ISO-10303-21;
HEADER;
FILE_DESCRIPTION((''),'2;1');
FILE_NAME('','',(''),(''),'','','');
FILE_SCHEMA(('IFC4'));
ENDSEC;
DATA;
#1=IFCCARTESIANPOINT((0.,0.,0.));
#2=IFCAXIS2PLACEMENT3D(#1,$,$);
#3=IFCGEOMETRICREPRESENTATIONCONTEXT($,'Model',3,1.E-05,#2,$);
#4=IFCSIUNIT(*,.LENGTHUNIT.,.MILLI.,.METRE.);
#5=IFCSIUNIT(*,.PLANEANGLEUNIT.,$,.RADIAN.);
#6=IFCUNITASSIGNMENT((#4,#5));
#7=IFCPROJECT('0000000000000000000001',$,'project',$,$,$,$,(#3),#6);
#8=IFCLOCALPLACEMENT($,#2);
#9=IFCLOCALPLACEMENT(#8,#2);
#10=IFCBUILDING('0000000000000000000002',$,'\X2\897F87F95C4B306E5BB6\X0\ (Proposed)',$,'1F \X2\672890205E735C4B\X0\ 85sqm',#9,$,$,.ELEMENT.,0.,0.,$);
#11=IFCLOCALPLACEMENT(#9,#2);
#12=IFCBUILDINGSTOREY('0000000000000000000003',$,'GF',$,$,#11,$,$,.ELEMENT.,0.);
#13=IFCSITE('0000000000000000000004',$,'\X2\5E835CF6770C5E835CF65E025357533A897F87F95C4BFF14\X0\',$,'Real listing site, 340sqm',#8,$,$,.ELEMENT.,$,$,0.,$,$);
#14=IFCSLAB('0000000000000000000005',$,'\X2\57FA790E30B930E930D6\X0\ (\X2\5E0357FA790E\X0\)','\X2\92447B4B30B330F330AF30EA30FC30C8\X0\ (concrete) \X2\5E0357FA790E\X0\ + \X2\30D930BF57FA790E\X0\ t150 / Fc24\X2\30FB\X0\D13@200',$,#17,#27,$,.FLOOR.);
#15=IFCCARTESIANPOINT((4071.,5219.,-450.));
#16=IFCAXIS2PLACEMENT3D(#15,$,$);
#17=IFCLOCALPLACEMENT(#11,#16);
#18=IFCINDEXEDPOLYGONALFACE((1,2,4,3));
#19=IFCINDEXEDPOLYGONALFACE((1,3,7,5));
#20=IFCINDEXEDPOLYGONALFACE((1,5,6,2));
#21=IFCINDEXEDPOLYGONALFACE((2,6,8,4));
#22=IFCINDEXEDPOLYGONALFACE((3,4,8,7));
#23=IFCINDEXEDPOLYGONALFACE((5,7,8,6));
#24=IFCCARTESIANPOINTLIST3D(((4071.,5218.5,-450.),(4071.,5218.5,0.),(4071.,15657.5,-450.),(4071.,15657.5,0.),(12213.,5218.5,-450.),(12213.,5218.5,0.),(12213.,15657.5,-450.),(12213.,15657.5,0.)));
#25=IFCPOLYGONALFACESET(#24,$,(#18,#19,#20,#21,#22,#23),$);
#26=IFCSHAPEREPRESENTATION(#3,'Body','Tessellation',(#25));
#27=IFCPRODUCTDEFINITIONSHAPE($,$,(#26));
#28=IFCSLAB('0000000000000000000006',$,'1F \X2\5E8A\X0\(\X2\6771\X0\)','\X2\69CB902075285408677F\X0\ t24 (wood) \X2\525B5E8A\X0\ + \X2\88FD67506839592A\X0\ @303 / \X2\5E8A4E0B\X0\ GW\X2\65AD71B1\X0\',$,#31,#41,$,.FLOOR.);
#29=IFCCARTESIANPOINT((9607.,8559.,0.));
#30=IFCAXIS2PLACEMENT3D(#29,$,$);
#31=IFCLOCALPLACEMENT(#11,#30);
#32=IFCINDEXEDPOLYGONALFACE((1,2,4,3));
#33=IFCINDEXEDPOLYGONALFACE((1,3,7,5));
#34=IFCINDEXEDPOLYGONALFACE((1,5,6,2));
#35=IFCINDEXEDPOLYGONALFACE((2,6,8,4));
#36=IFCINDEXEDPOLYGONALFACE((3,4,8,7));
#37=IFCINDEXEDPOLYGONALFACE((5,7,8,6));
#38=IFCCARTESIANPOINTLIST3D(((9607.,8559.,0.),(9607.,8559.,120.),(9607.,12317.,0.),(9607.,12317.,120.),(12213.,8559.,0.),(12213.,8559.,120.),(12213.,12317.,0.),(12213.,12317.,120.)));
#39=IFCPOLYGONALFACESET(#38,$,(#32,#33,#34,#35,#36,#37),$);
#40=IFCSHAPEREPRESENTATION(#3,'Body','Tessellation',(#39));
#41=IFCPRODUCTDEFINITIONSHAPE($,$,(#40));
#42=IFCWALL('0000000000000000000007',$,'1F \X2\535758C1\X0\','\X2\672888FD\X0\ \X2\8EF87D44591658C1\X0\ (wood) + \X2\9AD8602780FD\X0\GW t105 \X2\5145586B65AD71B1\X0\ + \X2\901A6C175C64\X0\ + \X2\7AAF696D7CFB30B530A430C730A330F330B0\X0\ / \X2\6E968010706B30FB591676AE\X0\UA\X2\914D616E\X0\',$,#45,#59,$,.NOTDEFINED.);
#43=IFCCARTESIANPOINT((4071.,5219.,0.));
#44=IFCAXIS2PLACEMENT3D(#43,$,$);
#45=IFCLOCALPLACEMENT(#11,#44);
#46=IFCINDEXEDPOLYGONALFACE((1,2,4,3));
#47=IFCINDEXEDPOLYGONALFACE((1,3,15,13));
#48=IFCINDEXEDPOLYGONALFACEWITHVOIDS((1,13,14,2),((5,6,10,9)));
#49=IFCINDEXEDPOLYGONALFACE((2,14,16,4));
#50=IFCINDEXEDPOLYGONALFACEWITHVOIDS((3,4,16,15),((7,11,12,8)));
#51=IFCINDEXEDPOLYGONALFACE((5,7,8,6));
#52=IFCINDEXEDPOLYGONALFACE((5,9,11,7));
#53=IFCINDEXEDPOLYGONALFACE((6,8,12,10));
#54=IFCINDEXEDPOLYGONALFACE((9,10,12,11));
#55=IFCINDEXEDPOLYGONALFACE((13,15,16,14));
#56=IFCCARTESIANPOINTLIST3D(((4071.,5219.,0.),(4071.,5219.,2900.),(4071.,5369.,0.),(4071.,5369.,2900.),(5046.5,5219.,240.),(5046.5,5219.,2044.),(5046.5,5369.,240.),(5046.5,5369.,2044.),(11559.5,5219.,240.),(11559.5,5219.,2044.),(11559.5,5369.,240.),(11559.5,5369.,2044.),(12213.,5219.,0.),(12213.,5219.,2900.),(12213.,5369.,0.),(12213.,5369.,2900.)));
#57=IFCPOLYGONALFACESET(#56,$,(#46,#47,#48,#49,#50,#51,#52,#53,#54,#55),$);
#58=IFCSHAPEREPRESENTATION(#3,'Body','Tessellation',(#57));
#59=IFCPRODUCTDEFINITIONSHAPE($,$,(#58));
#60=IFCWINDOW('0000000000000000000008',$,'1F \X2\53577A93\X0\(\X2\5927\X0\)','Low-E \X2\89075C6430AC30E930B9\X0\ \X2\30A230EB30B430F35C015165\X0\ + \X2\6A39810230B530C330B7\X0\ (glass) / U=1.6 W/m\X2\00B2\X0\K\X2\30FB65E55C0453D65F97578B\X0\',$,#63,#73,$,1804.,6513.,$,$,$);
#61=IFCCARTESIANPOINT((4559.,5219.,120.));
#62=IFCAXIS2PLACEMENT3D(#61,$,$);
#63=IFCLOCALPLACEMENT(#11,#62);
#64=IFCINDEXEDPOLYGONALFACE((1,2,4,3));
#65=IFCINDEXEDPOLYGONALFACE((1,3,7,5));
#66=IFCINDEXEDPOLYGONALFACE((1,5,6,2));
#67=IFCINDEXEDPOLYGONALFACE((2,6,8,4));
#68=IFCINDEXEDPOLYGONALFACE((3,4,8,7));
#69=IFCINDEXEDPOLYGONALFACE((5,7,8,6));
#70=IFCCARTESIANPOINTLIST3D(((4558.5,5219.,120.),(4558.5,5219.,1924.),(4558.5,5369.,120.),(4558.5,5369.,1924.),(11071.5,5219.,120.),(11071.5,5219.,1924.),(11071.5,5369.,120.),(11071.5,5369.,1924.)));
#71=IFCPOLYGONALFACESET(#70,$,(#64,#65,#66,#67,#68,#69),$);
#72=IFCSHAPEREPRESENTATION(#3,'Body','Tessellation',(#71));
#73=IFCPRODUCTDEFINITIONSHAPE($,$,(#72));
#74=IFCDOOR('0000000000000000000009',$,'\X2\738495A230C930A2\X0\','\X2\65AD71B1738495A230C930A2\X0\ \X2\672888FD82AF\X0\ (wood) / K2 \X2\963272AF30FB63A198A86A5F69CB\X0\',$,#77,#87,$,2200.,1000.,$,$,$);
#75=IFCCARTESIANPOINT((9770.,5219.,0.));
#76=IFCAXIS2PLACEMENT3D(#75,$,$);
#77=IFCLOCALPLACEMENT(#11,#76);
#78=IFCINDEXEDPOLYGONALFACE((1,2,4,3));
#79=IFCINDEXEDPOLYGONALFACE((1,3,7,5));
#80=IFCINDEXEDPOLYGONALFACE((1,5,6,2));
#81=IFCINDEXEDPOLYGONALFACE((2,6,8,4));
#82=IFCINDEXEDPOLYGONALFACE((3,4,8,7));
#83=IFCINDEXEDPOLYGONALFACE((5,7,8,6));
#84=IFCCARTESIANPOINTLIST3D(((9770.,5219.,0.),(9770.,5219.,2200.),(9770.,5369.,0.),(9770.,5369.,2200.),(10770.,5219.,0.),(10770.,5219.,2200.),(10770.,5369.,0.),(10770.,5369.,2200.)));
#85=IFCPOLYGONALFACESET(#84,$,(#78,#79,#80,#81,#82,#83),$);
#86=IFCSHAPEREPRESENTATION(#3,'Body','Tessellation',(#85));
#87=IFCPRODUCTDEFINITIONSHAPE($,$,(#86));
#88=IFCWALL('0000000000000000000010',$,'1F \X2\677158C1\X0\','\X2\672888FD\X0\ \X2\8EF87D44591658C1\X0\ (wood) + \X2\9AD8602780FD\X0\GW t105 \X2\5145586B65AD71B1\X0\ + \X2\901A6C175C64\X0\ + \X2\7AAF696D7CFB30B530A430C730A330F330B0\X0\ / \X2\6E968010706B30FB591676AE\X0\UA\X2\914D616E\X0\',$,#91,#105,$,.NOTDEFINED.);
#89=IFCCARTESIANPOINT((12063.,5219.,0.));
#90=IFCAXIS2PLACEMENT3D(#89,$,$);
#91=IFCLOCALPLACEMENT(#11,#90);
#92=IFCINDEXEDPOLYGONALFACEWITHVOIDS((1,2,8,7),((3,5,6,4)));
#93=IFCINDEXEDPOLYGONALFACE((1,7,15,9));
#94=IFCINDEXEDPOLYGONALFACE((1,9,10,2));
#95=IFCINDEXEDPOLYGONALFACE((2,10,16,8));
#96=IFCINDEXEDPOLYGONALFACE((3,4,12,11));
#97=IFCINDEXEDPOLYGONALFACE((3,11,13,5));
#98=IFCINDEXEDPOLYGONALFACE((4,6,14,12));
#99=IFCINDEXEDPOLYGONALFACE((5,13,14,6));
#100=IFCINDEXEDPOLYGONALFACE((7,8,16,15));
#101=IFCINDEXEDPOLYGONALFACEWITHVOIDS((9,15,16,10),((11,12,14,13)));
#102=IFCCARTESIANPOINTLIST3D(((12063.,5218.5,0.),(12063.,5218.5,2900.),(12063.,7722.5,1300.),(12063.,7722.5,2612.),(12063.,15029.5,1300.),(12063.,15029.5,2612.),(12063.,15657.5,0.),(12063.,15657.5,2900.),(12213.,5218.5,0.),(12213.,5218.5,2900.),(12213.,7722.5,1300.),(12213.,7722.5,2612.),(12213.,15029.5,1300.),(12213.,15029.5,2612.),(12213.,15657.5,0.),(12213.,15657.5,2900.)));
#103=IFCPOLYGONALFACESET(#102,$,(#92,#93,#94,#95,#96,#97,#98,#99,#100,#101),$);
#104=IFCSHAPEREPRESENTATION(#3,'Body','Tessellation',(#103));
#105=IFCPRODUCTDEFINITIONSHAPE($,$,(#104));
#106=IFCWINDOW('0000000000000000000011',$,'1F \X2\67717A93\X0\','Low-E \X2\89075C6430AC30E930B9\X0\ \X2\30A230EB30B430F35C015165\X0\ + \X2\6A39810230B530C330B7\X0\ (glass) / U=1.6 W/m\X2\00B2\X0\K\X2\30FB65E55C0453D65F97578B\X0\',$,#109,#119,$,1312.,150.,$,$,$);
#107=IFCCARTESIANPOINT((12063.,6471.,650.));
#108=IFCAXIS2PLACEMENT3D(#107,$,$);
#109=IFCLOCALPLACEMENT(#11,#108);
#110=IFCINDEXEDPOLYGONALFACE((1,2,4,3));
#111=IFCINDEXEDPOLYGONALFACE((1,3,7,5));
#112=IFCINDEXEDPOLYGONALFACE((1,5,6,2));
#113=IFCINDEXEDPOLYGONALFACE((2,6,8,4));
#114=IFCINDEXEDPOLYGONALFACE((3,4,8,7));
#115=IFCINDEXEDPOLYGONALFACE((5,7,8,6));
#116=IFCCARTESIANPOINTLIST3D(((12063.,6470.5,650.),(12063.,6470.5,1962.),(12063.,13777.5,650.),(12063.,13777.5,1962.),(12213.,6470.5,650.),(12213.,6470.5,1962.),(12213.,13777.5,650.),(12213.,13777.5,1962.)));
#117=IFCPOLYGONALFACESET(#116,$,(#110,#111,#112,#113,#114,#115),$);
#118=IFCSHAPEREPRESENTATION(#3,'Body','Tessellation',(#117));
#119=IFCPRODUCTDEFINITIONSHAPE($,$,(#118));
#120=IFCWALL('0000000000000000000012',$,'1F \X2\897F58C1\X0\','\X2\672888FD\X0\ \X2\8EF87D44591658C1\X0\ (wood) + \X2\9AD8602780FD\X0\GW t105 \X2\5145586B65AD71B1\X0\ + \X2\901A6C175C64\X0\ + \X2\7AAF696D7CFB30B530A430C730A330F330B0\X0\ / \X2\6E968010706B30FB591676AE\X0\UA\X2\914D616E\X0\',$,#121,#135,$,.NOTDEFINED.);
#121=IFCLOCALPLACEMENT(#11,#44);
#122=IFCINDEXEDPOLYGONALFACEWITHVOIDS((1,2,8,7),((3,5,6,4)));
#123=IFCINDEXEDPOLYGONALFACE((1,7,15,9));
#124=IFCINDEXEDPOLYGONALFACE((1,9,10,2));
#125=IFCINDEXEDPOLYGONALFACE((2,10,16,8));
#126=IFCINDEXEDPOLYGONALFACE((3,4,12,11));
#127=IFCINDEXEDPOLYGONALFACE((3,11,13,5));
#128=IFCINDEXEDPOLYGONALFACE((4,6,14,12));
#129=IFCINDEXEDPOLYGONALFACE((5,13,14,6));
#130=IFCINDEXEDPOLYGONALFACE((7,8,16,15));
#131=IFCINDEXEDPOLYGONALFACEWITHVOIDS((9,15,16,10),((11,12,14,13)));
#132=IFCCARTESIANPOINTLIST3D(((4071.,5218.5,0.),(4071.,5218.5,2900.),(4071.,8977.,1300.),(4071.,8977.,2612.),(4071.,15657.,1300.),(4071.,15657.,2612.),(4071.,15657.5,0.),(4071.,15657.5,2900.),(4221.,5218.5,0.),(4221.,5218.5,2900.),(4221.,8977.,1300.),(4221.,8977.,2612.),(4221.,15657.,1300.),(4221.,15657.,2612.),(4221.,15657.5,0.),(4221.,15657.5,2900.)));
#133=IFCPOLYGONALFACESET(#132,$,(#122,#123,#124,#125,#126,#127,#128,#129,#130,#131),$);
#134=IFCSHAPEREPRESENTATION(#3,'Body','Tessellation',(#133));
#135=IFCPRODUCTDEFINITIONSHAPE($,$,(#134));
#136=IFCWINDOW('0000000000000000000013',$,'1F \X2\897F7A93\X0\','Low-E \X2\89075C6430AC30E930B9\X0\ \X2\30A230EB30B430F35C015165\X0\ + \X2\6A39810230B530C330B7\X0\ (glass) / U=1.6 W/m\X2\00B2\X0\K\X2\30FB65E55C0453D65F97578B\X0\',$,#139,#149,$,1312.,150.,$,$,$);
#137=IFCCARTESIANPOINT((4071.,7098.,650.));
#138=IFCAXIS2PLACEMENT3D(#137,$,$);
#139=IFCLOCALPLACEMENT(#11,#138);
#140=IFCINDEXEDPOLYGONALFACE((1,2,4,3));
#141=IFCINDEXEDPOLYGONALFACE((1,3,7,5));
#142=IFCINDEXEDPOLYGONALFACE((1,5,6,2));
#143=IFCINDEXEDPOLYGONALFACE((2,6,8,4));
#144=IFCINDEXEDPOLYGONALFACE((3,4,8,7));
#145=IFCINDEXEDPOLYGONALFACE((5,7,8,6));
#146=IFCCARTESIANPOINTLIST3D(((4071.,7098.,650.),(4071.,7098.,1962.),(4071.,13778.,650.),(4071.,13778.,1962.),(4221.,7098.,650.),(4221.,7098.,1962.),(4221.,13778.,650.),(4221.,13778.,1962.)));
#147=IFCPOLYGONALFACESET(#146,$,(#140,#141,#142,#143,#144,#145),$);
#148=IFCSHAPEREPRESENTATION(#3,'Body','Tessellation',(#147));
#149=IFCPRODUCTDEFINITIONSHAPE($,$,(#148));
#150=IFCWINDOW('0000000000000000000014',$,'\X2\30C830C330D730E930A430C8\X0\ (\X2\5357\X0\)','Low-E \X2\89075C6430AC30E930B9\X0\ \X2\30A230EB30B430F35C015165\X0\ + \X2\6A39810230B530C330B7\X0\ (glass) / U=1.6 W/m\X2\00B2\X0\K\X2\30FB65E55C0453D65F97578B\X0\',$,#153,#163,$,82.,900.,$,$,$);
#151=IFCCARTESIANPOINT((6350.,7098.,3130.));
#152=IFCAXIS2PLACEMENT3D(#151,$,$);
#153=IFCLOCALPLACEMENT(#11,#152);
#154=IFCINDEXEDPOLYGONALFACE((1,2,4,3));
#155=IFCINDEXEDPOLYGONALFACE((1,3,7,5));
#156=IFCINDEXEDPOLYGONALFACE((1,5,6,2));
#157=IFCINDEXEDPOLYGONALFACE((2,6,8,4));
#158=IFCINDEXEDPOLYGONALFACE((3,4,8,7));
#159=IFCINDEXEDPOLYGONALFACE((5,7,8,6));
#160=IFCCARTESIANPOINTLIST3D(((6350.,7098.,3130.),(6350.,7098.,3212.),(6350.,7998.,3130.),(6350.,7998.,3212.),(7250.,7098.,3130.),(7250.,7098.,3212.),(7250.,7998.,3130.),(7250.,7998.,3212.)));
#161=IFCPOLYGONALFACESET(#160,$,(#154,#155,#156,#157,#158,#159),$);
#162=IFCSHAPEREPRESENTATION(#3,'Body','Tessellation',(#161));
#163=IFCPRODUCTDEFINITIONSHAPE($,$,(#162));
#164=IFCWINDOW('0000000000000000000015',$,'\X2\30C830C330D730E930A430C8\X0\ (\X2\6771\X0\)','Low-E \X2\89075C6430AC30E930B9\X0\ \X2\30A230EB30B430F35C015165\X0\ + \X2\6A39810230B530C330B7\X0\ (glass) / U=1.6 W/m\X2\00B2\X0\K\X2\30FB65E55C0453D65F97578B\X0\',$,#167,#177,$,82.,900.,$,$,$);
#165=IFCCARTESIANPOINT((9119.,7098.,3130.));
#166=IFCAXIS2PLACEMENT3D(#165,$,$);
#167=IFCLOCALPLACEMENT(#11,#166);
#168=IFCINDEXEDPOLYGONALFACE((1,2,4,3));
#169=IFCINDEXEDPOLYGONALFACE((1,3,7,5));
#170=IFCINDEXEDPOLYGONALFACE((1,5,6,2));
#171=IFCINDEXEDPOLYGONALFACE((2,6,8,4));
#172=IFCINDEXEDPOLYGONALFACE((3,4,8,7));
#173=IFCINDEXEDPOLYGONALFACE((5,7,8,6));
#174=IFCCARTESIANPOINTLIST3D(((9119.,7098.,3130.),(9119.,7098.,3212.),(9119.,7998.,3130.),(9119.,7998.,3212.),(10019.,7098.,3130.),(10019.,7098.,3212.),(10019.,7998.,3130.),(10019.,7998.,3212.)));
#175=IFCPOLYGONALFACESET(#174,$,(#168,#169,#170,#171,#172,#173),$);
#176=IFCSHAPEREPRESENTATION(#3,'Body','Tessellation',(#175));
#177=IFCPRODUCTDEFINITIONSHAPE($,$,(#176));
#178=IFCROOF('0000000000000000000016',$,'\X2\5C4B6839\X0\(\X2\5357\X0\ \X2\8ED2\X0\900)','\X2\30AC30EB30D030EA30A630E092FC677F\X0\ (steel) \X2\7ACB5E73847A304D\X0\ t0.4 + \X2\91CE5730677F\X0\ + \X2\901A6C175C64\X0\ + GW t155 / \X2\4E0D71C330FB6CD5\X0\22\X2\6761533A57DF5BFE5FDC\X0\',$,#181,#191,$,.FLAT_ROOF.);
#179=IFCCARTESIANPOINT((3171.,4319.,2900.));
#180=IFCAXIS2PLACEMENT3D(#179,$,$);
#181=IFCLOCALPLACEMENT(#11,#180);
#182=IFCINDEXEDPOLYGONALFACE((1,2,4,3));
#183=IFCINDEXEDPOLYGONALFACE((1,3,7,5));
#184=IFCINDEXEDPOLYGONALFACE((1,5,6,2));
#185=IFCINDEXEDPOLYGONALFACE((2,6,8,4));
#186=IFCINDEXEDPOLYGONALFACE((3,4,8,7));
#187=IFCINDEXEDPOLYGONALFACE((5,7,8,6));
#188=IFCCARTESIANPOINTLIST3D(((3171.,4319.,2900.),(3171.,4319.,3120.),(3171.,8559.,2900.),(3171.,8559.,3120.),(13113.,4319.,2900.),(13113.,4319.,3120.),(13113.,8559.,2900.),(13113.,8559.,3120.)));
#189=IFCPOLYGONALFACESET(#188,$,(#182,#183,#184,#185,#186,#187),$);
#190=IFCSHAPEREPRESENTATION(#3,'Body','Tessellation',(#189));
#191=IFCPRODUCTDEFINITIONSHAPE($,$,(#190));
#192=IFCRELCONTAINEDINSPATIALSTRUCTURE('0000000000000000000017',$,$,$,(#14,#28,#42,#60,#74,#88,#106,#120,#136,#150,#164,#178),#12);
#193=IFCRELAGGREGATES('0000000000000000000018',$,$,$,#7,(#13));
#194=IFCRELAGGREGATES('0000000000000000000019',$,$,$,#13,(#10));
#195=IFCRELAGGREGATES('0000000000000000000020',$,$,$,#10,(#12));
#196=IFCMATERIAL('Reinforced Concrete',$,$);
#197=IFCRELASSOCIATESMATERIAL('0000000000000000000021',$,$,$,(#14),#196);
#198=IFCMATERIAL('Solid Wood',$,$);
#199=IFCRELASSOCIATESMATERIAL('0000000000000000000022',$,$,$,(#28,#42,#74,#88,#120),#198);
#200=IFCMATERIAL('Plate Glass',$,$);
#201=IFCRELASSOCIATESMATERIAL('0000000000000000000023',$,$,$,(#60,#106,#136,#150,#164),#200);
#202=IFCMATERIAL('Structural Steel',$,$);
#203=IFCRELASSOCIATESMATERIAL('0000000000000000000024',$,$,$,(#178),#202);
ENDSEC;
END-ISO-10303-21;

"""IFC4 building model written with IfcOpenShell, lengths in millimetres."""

from ifc_helpers import new_model, si_unit, frame, frame_2d, origin, place, context, project, spatial, rectangle, extrude, material, element, fill, save


model = new_model("IFC4")

# Units and contexts
model_context = context("Model", 3, precision=1e-05, world=origin())
ifc_project = project(units=[si_unit("LENGTHUNIT", "METRE", prefix="MILLI"), si_unit("PLANEANGLEUNIT", "RADIAN")], contexts=[model_context])

# Site, building, storey
site_placement = place(None, origin())
site = spatial("IfcSite", under=ifc_project, at=site_placement, Name="広島県広島市南区西蟹屋４", ObjectType="Real listing site, 340sqm", CompositionType="ELEMENT", RefElevation=0.0)
building_placement = place(site_placement, origin())
building = spatial("IfcBuilding", under=site, at=building_placement, Name="西蟹屋の家 (Proposed)", ObjectType="1F 木造平屋 85sqm", CompositionType="ELEMENT", ElevationOfRefHeight=0.0, ElevationOfTerrain=0.0)
storey_placement = place(building_placement, origin())
storey = spatial("IfcBuildingStorey", under=building, at=storey_placement, Name="GF", CompositionType="ELEMENT", Elevation=0.0)

# Slabs
ifc_material_1 = material(Name="Reinforced Concrete")
slab_1_placement = place(storey_placement, frame((4071.0, 5219.0, -450.0)))
element("IfcSlab", 1, at=slab_1_placement, inside=storey, material=ifc_material_1, Name="基礎スラブ (布基礎)", Description="鉄筋コンクリート (concrete) 布基礎 + ベタ基礎 t150 / Fc24・D13@200", PredefinedType="FLOOR", context=model_context, shape_type="SweptSolid", body=[
    extrude(rectangle(XDim=8142.0, YDim=10439.0, at=frame_2d((4071.0, 5219.0))), frame((4071.0, 5219.0, -450.0)), (0.0, 0.0, 1.0), 450.0),
])
ifc_material_2 = material(Name="Solid Wood")
slab_2_placement = place(storey_placement, frame((9607.0, 8559.0, 0.0)))
element("IfcSlab", 2, at=slab_2_placement, inside=storey, material=ifc_material_2, Name="1F 床(東)", Description="構造用合板 t24 (wood) 剛床 + 製材根太 @303 / 床下 GW断熱", PredefinedType="FLOOR", context=model_context, shape_type="SweptSolid", body=[
    extrude(rectangle(XDim=2606.0, YDim=3758.0, at=frame_2d((1303.0, 1879.0))), frame((9607.0, 8559.0, 0.0)), (0.0, 0.0, 1.0), 120.0),
])

# Wall, openings, window, door
wall_1_placement = place(storey_placement, frame((4071.0, 5219.0, 0.0)))
wall_1 = element("IfcWall", 3, at=wall_1_placement, inside=storey, material=ifc_material_2, Name="1F 南壁", Description="木製 軸組外壁 (wood) + 高性能GW t105 充填断熱 + 通気層 + 窯業系サイディング / 準耐火・外皮UA配慮", PredefinedType="NOTDEFINED", context=model_context, shape_type="SweptSolid", body=[
    extrude(rectangle(XDim=8142.0, YDim=150.0, at=frame_2d((4071.0, 75.0))), frame((4071.0, 5219.0, 0.0)), (0.0, 0.0, 1.0), 2900.0),
])
opening_1_placement = place(storey_placement, frame((4559.0, 5219.0, 120.0)))
opening_1 = element("IfcOpeningElement", 4, at=opening_1_placement, cuts=wall_1, PredefinedType="NOTDEFINED", context=model_context, shape_type="SweptSolid", body=[
    extrude(rectangle(XDim=6513.0, YDim=150.0, at=frame_2d((3256.0, 75.0))), frame((4559.0, 5219.0, 120.0)), (0.0, 0.0, 1.0), 1804.0),
])
opening_2_placement = place(storey_placement, frame((9770.0, 5219.0, 0.0)))
opening_2 = element("IfcOpeningElement", 5, at=opening_2_placement, cuts=wall_1, PredefinedType="NOTDEFINED", context=model_context, shape_type="SweptSolid", body=[
    extrude(rectangle(XDim=1000.0, YDim=150.0, at=frame_2d((500.0, 75.0))), frame((9770.0, 5219.0, 0.0)), (0.0, 0.0, 1.0), 2200.0),
])
ifc_material_3 = material(Name="Plate Glass")
window_1_placement = place(storey_placement, frame((4559.0, 5219.0, 120.0)))
window_1 = element("IfcWindow", 6, at=window_1_placement, inside=storey, material=ifc_material_3, Name="1F 南窓(大)", Description="Low-E 複層ガラス アルゴン封入 + 樹脂サッシ (glass) / U=1.6 W/m²K・日射取得型", OverallHeight=1804.0, OverallWidth=6513.0, context=model_context, shape_type="SweptSolid", body=[
    extrude(rectangle(XDim=6513.0, YDim=150.0, at=frame_2d((3256.0, 75.0))), frame((4559.0, 5219.0, 120.0)), (0.0, 0.0, 1.0), 1804.0),
])
fill(opening_1, window_1)
door_placement = place(storey_placement, frame((9770.0, 5219.0, 0.0)))
door = element("IfcDoor", 7, at=door_placement, inside=storey, material=ifc_material_2, Name="玄関ドア", Description="断熱玄関ドア 木製芯 (wood) / K2 防犯・採風機構", OverallHeight=2200.0, OverallWidth=1000.0, context=model_context, shape_type="SweptSolid", body=[
    extrude(rectangle(XDim=1000.0, YDim=150.0, at=frame_2d((500.0, 75.0))), frame((9770.0, 5219.0, 0.0)), (0.0, 0.0, 1.0), 2200.0),
])
fill(opening_2, door)

# Walls, openings, windows
wall_2_placement = place(storey_placement, frame((12063.0, 5219.0, 0.0)))
wall_2 = element("IfcWall", 8, at=wall_2_placement, inside=storey, material=ifc_material_2, Name="1F 東壁", Description="木製 軸組外壁 (wood) + 高性能GW t105 充填断熱 + 通気層 + 窯業系サイディング / 準耐火・外皮UA配慮", PredefinedType="NOTDEFINED", context=model_context, shape_type="SweptSolid", body=[
    extrude(rectangle(XDim=150.0, YDim=10439.0, at=frame_2d((75.0, 5219.0))), frame((12063.0, 5219.0, 0.0)), (0.0, 0.0, 1.0), 2900.0),
])
opening_3_placement = place(storey_placement, frame((12063.0, 6471.0, 650.0)))
opening_3 = element("IfcOpeningElement", 9, at=opening_3_placement, cuts=wall_2, PredefinedType="NOTDEFINED", context=model_context, shape_type="SweptSolid", body=[
    extrude(rectangle(XDim=150.0, YDim=7307.0, at=frame_2d((75.0, 3653.0))), frame((12063.0, 6471.0, 650.0)), (0.0, 0.0, 1.0), 1312.0),
])
window_2_placement = place(storey_placement, frame((12063.0, 6471.0, 650.0)))
window_2 = element("IfcWindow", 10, at=window_2_placement, inside=storey, material=ifc_material_3, Name="1F 東窓", Description="Low-E 複層ガラス アルゴン封入 + 樹脂サッシ (glass) / U=1.6 W/m²K・日射取得型", OverallHeight=1312.0, OverallWidth=150.0, context=model_context, shape_type="SweptSolid", body=[
    extrude(rectangle(XDim=150.0, YDim=7307.0, at=frame_2d((75.0, 3653.0))), frame((12063.0, 6471.0, 650.0)), (0.0, 0.0, 1.0), 1312.0),
])
fill(opening_3, window_2)
wall_3_placement = place(storey_placement, frame((4071.0, 5219.0, 0.0)))
wall_3 = element("IfcWall", 11, at=wall_3_placement, inside=storey, material=ifc_material_2, Name="1F 西壁", Description="木製 軸組外壁 (wood) + 高性能GW t105 充填断熱 + 通気層 + 窯業系サイディング / 準耐火・外皮UA配慮", PredefinedType="NOTDEFINED", context=model_context, shape_type="SweptSolid", body=[
    extrude(rectangle(XDim=150.0, YDim=10439.0, at=frame_2d((75.0, 5219.0))), frame((4071.0, 5219.0, 0.0)), (0.0, 0.0, 1.0), 2900.0),
])
opening_4_placement = place(storey_placement, frame((4071.0, 7098.0, 650.0)))
opening_4 = element("IfcOpeningElement", 12, at=opening_4_placement, cuts=wall_3, PredefinedType="NOTDEFINED", context=model_context, shape_type="SweptSolid", body=[
    extrude(rectangle(XDim=150.0, YDim=6680.0, at=frame_2d((75.0, 3340.0))), frame((4071.0, 7098.0, 650.0)), (0.0, 0.0, 1.0), 1312.0),
])
window_3_placement = place(storey_placement, frame((4071.0, 7098.0, 650.0)))
window_3 = element("IfcWindow", 13, at=window_3_placement, inside=storey, material=ifc_material_3, Name="1F 西窓", Description="Low-E 複層ガラス アルゴン封入 + 樹脂サッシ (glass) / U=1.6 W/m²K・日射取得型", OverallHeight=1312.0, OverallWidth=150.0, context=model_context, shape_type="SweptSolid", body=[
    extrude(rectangle(XDim=150.0, YDim=6680.0, at=frame_2d((75.0, 3340.0))), frame((4071.0, 7098.0, 650.0)), (0.0, 0.0, 1.0), 1312.0),
])
fill(opening_4, window_3)

# Windows
window_4_placement = place(storey_placement, frame((6350.0, 7098.0, 3130.0)))
element("IfcWindow", 14, at=window_4_placement, inside=storey, material=ifc_material_3, Name="トップライト (南)", Description="Low-E 複層ガラス アルゴン封入 + 樹脂サッシ (glass) / U=1.6 W/m²K・日射取得型", OverallHeight=82.0, OverallWidth=900.0, context=model_context, shape_type="SweptSolid", body=[
    extrude(rectangle(XDim=900.0, YDim=900.0, at=frame_2d((450.0, 450.0))), frame((6350.0, 7098.0, 3130.0)), (0.0, 0.0, 1.0), 82.0),
])
window_5_placement = place(storey_placement, frame((9119.0, 7098.0, 3130.0)))
element("IfcWindow", 15, at=window_5_placement, inside=storey, material=ifc_material_3, Name="トップライト (東)", Description="Low-E 複層ガラス アルゴン封入 + 樹脂サッシ (glass) / U=1.6 W/m²K・日射取得型", OverallHeight=82.0, OverallWidth=900.0, context=model_context, shape_type="SweptSolid", body=[
    extrude(rectangle(XDim=900.0, YDim=900.0, at=frame_2d((450.0, 450.0))), frame((9119.0, 7098.0, 3130.0)), (0.0, 0.0, 1.0), 82.0),
])

# Roof
ifc_material_4 = material(Name="Structural Steel")
roof_placement = place(storey_placement, frame((3171.0, 4319.0, 2900.0)))
element("IfcRoof", 16, at=roof_placement, inside=storey, material=ifc_material_4, Name="屋根(南 軒900)", Description="ガルバリウム鋼板 (steel) 立平葺き t0.4 + 野地板 + 通気層 + GW t155 / 不燃・法22条区域対応", PredefinedType="FLAT_ROOF", context=model_context, shape_type="SweptSolid", body=[
    extrude(rectangle(XDim=9942.0, YDim=4240.0, at=frame_2d((4971.0, 2120.0))), frame((3171.0, 4319.0, 2900.0)), (0.0, 0.0, 1.0), 220.0),
])

save(model, "model.ifc")
